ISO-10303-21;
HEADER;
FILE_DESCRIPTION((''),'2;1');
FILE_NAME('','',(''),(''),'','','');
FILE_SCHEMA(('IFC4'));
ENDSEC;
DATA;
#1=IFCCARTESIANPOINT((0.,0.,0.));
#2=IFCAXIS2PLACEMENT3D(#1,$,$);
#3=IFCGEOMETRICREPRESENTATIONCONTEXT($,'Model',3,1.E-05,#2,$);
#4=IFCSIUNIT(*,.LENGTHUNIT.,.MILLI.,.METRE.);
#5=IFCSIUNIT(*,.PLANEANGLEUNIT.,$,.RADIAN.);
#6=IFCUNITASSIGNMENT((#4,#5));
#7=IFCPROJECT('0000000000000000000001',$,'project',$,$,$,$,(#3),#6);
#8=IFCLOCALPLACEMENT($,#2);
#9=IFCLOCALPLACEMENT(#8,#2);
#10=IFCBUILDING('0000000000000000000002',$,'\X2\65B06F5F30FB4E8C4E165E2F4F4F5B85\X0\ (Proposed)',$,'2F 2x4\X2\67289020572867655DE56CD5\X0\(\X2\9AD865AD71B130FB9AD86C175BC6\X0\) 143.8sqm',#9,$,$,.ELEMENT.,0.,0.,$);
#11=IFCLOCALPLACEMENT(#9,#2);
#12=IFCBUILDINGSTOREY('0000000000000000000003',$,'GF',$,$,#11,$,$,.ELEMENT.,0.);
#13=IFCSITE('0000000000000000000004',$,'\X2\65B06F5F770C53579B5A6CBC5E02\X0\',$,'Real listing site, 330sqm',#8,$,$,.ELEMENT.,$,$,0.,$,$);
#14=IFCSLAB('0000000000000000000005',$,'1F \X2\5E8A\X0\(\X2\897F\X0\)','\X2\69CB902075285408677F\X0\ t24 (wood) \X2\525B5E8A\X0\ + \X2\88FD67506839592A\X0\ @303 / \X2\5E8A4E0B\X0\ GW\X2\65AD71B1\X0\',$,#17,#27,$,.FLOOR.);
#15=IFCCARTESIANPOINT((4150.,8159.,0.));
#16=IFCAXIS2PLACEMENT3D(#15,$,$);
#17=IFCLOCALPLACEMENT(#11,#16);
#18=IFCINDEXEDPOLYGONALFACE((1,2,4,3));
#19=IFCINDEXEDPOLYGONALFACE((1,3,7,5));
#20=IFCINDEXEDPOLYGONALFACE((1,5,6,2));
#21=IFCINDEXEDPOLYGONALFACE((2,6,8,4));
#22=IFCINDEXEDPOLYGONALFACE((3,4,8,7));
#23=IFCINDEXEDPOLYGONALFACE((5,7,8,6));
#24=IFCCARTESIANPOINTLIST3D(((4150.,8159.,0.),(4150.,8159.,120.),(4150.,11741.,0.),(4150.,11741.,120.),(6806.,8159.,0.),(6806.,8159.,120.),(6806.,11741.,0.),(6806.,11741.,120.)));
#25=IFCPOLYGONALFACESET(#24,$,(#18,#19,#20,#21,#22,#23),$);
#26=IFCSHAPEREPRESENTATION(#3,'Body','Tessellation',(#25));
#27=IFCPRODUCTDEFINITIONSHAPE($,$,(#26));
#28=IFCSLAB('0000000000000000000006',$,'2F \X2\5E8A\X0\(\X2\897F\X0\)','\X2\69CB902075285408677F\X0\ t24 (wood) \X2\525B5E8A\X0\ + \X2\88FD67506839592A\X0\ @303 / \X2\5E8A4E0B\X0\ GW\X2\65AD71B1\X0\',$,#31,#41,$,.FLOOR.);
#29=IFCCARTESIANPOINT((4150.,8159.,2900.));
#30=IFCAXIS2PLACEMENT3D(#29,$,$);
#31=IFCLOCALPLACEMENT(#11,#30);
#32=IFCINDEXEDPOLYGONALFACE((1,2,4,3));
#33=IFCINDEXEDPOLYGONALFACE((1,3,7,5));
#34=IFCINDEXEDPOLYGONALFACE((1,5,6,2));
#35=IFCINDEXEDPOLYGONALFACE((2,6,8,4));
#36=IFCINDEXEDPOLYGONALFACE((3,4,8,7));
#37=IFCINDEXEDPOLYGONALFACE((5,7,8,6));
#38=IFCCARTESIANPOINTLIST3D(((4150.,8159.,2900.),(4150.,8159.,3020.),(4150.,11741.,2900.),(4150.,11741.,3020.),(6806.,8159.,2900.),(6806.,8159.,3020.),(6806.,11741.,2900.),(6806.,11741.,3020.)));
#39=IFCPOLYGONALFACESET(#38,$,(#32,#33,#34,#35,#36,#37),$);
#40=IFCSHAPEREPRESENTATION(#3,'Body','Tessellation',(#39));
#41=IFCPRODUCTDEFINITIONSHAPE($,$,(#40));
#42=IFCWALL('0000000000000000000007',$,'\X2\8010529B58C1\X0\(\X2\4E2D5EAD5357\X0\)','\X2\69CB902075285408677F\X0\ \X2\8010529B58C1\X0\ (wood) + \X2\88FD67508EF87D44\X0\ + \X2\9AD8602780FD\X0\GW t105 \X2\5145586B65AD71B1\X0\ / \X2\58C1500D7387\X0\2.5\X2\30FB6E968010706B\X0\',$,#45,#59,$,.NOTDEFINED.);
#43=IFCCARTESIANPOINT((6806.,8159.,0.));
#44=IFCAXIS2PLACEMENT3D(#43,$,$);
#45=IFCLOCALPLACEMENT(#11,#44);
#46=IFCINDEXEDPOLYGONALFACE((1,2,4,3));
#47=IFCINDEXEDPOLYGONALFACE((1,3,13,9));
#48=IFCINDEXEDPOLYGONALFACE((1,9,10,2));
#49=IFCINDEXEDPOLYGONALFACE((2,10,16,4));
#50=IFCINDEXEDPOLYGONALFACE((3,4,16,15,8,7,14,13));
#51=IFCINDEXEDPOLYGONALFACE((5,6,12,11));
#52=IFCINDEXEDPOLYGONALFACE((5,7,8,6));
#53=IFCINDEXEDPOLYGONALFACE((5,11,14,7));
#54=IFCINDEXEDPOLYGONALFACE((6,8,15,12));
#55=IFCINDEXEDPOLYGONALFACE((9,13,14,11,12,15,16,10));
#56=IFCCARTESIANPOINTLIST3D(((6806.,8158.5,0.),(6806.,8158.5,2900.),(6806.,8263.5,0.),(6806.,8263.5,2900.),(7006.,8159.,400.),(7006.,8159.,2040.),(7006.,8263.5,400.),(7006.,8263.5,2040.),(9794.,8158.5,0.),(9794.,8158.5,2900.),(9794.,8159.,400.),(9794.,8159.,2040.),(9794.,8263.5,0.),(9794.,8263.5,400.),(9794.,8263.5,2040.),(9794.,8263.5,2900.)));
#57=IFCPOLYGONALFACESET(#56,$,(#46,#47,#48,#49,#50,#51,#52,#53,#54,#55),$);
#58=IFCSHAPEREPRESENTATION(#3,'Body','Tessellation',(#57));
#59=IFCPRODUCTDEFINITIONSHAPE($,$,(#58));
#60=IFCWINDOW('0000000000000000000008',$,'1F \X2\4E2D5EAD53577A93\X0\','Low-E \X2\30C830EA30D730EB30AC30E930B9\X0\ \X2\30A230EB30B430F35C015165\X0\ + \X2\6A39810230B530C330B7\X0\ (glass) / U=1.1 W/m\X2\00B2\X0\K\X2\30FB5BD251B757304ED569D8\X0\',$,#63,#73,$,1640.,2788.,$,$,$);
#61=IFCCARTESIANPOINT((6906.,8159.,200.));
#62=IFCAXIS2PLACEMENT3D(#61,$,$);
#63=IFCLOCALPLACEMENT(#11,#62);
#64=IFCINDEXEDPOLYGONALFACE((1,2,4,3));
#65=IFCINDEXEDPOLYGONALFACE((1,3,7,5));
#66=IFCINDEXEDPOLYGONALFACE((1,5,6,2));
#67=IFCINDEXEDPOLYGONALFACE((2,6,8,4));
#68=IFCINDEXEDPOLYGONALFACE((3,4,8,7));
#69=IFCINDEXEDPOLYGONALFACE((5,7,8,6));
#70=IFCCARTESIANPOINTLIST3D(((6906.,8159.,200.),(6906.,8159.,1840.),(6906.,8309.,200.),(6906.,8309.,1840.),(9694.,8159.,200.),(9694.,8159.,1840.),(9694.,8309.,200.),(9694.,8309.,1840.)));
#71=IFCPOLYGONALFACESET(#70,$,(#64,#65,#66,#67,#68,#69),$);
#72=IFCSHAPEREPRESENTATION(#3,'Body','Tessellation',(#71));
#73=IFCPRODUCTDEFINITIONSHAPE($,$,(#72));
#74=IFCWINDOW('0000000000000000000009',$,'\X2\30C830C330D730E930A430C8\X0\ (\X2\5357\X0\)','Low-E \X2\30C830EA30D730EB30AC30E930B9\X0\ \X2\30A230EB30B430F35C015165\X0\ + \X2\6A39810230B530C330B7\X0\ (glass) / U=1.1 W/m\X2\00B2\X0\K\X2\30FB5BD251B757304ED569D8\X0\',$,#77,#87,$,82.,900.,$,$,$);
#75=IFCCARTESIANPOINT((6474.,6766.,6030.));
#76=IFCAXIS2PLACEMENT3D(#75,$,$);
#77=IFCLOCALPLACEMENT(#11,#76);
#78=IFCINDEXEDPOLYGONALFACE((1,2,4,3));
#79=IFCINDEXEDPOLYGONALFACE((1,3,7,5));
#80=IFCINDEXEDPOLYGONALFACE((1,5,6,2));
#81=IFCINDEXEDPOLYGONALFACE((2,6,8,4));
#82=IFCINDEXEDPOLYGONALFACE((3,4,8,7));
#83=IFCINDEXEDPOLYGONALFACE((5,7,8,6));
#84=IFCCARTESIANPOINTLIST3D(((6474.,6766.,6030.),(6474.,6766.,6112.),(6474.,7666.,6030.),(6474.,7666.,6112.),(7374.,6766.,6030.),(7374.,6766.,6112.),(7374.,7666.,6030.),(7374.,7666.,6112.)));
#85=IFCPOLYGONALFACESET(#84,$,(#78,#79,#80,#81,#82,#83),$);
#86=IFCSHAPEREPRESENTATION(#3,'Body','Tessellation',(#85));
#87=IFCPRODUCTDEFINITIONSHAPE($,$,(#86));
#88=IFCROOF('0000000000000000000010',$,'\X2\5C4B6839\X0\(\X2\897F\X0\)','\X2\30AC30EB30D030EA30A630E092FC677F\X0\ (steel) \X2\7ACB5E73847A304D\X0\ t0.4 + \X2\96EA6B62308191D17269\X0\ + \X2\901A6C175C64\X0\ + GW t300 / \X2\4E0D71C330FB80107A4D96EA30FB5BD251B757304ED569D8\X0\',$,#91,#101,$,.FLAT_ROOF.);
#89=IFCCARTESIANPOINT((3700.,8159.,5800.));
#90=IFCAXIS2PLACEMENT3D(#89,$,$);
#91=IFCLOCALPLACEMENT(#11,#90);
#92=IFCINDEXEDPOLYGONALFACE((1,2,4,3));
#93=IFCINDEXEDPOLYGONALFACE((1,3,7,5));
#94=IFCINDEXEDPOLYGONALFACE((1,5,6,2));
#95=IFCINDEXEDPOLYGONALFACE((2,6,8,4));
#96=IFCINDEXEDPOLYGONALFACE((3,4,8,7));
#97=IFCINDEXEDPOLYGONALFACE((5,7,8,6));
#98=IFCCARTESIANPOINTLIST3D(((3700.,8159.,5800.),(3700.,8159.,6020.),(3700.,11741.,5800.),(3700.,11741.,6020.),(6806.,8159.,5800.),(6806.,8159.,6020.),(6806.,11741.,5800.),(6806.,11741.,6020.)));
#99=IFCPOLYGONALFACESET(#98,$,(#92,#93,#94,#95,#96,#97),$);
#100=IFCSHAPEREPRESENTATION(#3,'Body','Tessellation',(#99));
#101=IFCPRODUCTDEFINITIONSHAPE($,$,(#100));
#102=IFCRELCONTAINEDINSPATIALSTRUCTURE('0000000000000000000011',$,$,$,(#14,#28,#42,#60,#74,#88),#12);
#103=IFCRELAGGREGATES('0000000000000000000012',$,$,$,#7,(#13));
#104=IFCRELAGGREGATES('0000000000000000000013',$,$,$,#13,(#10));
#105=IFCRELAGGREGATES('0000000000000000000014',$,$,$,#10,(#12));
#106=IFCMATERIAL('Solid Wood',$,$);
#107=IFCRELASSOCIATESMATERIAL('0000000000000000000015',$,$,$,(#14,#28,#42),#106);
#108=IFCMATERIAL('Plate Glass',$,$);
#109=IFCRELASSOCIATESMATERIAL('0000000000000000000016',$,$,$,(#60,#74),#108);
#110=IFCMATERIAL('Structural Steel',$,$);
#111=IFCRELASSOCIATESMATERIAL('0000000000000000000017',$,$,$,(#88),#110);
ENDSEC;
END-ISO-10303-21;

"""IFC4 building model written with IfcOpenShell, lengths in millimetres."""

from ifc_helpers import new_model, si_unit, frame, frame_2d, origin, place, context, project, spatial, rectangle, extrude, material, element, fill, save


model = new_model("IFC4")

# Units and contexts
model_context = context("Model", 3, precision=1e-05, world=origin())
ifc_project = project(units=[si_unit("LENGTHUNIT", "METRE", prefix="MILLI"), si_unit("PLANEANGLEUNIT", "RADIAN")], contexts=[model_context])

# Site, building, storey
site_placement = place(None, origin())
site = spatial("IfcSite", under=ifc_project, at=site_placement, Name="新潟県南魚沼市", ObjectType="Real listing site, 330sqm", CompositionType="ELEMENT", RefElevation=0.0)
building_placement = place(site_placement, origin())
building = spatial("IfcBuilding", under=site, at=building_placement, Name="新潟・二世帯住宅 (Proposed)", ObjectType="2F 2x4木造在来工法(高断熱・高気密) 143.8sqm", CompositionType="ELEMENT", ElevationOfRefHeight=0.0, ElevationOfTerrain=0.0)
storey_placement = place(building_placement, origin())
storey = spatial("IfcBuildingStorey", under=building, at=storey_placement, Name="GF", CompositionType="ELEMENT", Elevation=0.0)

# Shared definitions
ifc_material_1 = material(Name="Solid Wood")

# Slabs
slab_1_placement = place(storey_placement, frame((4150.0, 8159.0, 0.0)))
element("IfcSlab", 1, at=slab_1_placement, inside=storey, material=ifc_material_1, Name="1F 床(西)", Description="構造用合板 t24 (wood) 剛床 + 製材根太 @303 / 床下 GW断熱", PredefinedType="FLOOR", context=model_context, shape_type="SweptSolid", body=[
    extrude(rectangle(XDim=2656.0, YDim=3582.0, at=frame_2d((1328.0, 1791.0))), frame((4150.0, 8159.0, 0.0)), (0.0, 0.0, 1.0), 120.0),
])
slab_2_placement = place(storey_placement, frame((4150.0, 8159.0, 2900.0)))
element("IfcSlab", 2, at=slab_2_placement, inside=storey, material=ifc_material_1, Name="2F 床(西)", Description="構造用合板 t24 (wood) 剛床 + 製材根太 @303 / 床下 GW断熱", PredefinedType="FLOOR", context=model_context, shape_type="SweptSolid", body=[
    extrude(rectangle(XDim=2656.0, YDim=3582.0, at=frame_2d((1328.0, 1791.0))), frame((4150.0, 8159.0, 2900.0)), (0.0, 0.0, 1.0), 120.0),
])

# Wall, opening, window
wall_placement = place(storey_placement, frame((6806.0, 8159.0, 0.0)))
wall = element("IfcWall", 3, at=wall_placement, inside=storey, material=ifc_material_1, Name="耐力壁(中庭南)", Description="構造用合板 耐力壁 (wood) + 製材軸組 + 高性能GW t105 充填断熱 / 壁倍率2.5・準耐火", PredefinedType="NOTDEFINED", context=model_context, shape_type="SweptSolid", body=[
    extrude(rectangle(XDim=2988.0, YDim=105.0, at=frame_2d((1494.0, 52.0))), frame((6806.0, 8159.0, 0.0)), (0.0, 0.0, 1.0), 2900.0),
])
opening_placement = place(storey_placement, frame((6906.0, 8159.0, 200.0)))
opening = element("IfcOpeningElement", 4, at=opening_placement, cuts=wall, PredefinedType="NOTDEFINED", context=model_context, shape_type="SweptSolid", body=[
    extrude(rectangle(XDim=2788.0, YDim=150.0, at=frame_2d((1394.0, 75.0))), frame((6906.0, 8159.0, 200.0)), (0.0, 0.0, 1.0), 1640.0),
])
ifc_material_2 = material(Name="Plate Glass")
window_1_placement = place(storey_placement, frame((6906.0, 8159.0, 200.0)))
window_1 = element("IfcWindow", 5, at=window_1_placement, inside=storey, material=ifc_material_2, Name="1F 中庭南窓", Description="Low-E トリプルガラス アルゴン封入 + 樹脂サッシ (glass) / U=1.1 W/m²K・寒冷地仕様", OverallHeight=1640.0, OverallWidth=2788.0, context=model_context, shape_type="SweptSolid", body=[
    extrude(rectangle(XDim=2788.0, YDim=150.0, at=frame_2d((1394.0, 75.0))), frame((6906.0, 8159.0, 200.0)), (0.0, 0.0, 1.0), 1640.0),
])
fill(opening, window_1)

# Window
window_2_placement = place(storey_placement, frame((6474.0, 6766.0, 6030.0)))
element("IfcWindow", 6, at=window_2_placement, inside=storey, material=ifc_material_2, Name="トップライト (南)", Description="Low-E トリプルガラス アルゴン封入 + 樹脂サッシ (glass) / U=1.1 W/m²K・寒冷地仕様", OverallHeight=82.0, OverallWidth=900.0, context=model_context, shape_type="SweptSolid", body=[
    extrude(rectangle(XDim=900.0, YDim=900.0, at=frame_2d((450.0, 450.0))), frame((6474.0, 6766.0, 6030.0)), (0.0, 0.0, 1.0), 82.0),
])

# Roof
ifc_material_3 = material(Name="Structural Steel")
for number, where, name in (
    (7, (3700.0, 8159.0, 5800.0), "屋根(西)"),
):
    element("IfcRoof", number, at=place(storey_placement, frame(where)), inside=storey, material=ifc_material_3, Name=name, Description="ガルバリウム鋼板 (steel) 立平葺き t0.4 + 雪止め金物 + 通気層 + GW t300 / 不燃・耐積雪・寒冷地仕様", PredefinedType="FLAT_ROOF", context=model_context, shape_type="SweptSolid", body=[
        extrude(rectangle(XDim=3106.0, YDim=3582.0, at=frame_2d((1553.0, 1791.0))), frame((3700.0, 8159.0, 5800.0)), (0.0, 0.0, 1.0), 220.0),
    ])

save(model, "model.ifc")
